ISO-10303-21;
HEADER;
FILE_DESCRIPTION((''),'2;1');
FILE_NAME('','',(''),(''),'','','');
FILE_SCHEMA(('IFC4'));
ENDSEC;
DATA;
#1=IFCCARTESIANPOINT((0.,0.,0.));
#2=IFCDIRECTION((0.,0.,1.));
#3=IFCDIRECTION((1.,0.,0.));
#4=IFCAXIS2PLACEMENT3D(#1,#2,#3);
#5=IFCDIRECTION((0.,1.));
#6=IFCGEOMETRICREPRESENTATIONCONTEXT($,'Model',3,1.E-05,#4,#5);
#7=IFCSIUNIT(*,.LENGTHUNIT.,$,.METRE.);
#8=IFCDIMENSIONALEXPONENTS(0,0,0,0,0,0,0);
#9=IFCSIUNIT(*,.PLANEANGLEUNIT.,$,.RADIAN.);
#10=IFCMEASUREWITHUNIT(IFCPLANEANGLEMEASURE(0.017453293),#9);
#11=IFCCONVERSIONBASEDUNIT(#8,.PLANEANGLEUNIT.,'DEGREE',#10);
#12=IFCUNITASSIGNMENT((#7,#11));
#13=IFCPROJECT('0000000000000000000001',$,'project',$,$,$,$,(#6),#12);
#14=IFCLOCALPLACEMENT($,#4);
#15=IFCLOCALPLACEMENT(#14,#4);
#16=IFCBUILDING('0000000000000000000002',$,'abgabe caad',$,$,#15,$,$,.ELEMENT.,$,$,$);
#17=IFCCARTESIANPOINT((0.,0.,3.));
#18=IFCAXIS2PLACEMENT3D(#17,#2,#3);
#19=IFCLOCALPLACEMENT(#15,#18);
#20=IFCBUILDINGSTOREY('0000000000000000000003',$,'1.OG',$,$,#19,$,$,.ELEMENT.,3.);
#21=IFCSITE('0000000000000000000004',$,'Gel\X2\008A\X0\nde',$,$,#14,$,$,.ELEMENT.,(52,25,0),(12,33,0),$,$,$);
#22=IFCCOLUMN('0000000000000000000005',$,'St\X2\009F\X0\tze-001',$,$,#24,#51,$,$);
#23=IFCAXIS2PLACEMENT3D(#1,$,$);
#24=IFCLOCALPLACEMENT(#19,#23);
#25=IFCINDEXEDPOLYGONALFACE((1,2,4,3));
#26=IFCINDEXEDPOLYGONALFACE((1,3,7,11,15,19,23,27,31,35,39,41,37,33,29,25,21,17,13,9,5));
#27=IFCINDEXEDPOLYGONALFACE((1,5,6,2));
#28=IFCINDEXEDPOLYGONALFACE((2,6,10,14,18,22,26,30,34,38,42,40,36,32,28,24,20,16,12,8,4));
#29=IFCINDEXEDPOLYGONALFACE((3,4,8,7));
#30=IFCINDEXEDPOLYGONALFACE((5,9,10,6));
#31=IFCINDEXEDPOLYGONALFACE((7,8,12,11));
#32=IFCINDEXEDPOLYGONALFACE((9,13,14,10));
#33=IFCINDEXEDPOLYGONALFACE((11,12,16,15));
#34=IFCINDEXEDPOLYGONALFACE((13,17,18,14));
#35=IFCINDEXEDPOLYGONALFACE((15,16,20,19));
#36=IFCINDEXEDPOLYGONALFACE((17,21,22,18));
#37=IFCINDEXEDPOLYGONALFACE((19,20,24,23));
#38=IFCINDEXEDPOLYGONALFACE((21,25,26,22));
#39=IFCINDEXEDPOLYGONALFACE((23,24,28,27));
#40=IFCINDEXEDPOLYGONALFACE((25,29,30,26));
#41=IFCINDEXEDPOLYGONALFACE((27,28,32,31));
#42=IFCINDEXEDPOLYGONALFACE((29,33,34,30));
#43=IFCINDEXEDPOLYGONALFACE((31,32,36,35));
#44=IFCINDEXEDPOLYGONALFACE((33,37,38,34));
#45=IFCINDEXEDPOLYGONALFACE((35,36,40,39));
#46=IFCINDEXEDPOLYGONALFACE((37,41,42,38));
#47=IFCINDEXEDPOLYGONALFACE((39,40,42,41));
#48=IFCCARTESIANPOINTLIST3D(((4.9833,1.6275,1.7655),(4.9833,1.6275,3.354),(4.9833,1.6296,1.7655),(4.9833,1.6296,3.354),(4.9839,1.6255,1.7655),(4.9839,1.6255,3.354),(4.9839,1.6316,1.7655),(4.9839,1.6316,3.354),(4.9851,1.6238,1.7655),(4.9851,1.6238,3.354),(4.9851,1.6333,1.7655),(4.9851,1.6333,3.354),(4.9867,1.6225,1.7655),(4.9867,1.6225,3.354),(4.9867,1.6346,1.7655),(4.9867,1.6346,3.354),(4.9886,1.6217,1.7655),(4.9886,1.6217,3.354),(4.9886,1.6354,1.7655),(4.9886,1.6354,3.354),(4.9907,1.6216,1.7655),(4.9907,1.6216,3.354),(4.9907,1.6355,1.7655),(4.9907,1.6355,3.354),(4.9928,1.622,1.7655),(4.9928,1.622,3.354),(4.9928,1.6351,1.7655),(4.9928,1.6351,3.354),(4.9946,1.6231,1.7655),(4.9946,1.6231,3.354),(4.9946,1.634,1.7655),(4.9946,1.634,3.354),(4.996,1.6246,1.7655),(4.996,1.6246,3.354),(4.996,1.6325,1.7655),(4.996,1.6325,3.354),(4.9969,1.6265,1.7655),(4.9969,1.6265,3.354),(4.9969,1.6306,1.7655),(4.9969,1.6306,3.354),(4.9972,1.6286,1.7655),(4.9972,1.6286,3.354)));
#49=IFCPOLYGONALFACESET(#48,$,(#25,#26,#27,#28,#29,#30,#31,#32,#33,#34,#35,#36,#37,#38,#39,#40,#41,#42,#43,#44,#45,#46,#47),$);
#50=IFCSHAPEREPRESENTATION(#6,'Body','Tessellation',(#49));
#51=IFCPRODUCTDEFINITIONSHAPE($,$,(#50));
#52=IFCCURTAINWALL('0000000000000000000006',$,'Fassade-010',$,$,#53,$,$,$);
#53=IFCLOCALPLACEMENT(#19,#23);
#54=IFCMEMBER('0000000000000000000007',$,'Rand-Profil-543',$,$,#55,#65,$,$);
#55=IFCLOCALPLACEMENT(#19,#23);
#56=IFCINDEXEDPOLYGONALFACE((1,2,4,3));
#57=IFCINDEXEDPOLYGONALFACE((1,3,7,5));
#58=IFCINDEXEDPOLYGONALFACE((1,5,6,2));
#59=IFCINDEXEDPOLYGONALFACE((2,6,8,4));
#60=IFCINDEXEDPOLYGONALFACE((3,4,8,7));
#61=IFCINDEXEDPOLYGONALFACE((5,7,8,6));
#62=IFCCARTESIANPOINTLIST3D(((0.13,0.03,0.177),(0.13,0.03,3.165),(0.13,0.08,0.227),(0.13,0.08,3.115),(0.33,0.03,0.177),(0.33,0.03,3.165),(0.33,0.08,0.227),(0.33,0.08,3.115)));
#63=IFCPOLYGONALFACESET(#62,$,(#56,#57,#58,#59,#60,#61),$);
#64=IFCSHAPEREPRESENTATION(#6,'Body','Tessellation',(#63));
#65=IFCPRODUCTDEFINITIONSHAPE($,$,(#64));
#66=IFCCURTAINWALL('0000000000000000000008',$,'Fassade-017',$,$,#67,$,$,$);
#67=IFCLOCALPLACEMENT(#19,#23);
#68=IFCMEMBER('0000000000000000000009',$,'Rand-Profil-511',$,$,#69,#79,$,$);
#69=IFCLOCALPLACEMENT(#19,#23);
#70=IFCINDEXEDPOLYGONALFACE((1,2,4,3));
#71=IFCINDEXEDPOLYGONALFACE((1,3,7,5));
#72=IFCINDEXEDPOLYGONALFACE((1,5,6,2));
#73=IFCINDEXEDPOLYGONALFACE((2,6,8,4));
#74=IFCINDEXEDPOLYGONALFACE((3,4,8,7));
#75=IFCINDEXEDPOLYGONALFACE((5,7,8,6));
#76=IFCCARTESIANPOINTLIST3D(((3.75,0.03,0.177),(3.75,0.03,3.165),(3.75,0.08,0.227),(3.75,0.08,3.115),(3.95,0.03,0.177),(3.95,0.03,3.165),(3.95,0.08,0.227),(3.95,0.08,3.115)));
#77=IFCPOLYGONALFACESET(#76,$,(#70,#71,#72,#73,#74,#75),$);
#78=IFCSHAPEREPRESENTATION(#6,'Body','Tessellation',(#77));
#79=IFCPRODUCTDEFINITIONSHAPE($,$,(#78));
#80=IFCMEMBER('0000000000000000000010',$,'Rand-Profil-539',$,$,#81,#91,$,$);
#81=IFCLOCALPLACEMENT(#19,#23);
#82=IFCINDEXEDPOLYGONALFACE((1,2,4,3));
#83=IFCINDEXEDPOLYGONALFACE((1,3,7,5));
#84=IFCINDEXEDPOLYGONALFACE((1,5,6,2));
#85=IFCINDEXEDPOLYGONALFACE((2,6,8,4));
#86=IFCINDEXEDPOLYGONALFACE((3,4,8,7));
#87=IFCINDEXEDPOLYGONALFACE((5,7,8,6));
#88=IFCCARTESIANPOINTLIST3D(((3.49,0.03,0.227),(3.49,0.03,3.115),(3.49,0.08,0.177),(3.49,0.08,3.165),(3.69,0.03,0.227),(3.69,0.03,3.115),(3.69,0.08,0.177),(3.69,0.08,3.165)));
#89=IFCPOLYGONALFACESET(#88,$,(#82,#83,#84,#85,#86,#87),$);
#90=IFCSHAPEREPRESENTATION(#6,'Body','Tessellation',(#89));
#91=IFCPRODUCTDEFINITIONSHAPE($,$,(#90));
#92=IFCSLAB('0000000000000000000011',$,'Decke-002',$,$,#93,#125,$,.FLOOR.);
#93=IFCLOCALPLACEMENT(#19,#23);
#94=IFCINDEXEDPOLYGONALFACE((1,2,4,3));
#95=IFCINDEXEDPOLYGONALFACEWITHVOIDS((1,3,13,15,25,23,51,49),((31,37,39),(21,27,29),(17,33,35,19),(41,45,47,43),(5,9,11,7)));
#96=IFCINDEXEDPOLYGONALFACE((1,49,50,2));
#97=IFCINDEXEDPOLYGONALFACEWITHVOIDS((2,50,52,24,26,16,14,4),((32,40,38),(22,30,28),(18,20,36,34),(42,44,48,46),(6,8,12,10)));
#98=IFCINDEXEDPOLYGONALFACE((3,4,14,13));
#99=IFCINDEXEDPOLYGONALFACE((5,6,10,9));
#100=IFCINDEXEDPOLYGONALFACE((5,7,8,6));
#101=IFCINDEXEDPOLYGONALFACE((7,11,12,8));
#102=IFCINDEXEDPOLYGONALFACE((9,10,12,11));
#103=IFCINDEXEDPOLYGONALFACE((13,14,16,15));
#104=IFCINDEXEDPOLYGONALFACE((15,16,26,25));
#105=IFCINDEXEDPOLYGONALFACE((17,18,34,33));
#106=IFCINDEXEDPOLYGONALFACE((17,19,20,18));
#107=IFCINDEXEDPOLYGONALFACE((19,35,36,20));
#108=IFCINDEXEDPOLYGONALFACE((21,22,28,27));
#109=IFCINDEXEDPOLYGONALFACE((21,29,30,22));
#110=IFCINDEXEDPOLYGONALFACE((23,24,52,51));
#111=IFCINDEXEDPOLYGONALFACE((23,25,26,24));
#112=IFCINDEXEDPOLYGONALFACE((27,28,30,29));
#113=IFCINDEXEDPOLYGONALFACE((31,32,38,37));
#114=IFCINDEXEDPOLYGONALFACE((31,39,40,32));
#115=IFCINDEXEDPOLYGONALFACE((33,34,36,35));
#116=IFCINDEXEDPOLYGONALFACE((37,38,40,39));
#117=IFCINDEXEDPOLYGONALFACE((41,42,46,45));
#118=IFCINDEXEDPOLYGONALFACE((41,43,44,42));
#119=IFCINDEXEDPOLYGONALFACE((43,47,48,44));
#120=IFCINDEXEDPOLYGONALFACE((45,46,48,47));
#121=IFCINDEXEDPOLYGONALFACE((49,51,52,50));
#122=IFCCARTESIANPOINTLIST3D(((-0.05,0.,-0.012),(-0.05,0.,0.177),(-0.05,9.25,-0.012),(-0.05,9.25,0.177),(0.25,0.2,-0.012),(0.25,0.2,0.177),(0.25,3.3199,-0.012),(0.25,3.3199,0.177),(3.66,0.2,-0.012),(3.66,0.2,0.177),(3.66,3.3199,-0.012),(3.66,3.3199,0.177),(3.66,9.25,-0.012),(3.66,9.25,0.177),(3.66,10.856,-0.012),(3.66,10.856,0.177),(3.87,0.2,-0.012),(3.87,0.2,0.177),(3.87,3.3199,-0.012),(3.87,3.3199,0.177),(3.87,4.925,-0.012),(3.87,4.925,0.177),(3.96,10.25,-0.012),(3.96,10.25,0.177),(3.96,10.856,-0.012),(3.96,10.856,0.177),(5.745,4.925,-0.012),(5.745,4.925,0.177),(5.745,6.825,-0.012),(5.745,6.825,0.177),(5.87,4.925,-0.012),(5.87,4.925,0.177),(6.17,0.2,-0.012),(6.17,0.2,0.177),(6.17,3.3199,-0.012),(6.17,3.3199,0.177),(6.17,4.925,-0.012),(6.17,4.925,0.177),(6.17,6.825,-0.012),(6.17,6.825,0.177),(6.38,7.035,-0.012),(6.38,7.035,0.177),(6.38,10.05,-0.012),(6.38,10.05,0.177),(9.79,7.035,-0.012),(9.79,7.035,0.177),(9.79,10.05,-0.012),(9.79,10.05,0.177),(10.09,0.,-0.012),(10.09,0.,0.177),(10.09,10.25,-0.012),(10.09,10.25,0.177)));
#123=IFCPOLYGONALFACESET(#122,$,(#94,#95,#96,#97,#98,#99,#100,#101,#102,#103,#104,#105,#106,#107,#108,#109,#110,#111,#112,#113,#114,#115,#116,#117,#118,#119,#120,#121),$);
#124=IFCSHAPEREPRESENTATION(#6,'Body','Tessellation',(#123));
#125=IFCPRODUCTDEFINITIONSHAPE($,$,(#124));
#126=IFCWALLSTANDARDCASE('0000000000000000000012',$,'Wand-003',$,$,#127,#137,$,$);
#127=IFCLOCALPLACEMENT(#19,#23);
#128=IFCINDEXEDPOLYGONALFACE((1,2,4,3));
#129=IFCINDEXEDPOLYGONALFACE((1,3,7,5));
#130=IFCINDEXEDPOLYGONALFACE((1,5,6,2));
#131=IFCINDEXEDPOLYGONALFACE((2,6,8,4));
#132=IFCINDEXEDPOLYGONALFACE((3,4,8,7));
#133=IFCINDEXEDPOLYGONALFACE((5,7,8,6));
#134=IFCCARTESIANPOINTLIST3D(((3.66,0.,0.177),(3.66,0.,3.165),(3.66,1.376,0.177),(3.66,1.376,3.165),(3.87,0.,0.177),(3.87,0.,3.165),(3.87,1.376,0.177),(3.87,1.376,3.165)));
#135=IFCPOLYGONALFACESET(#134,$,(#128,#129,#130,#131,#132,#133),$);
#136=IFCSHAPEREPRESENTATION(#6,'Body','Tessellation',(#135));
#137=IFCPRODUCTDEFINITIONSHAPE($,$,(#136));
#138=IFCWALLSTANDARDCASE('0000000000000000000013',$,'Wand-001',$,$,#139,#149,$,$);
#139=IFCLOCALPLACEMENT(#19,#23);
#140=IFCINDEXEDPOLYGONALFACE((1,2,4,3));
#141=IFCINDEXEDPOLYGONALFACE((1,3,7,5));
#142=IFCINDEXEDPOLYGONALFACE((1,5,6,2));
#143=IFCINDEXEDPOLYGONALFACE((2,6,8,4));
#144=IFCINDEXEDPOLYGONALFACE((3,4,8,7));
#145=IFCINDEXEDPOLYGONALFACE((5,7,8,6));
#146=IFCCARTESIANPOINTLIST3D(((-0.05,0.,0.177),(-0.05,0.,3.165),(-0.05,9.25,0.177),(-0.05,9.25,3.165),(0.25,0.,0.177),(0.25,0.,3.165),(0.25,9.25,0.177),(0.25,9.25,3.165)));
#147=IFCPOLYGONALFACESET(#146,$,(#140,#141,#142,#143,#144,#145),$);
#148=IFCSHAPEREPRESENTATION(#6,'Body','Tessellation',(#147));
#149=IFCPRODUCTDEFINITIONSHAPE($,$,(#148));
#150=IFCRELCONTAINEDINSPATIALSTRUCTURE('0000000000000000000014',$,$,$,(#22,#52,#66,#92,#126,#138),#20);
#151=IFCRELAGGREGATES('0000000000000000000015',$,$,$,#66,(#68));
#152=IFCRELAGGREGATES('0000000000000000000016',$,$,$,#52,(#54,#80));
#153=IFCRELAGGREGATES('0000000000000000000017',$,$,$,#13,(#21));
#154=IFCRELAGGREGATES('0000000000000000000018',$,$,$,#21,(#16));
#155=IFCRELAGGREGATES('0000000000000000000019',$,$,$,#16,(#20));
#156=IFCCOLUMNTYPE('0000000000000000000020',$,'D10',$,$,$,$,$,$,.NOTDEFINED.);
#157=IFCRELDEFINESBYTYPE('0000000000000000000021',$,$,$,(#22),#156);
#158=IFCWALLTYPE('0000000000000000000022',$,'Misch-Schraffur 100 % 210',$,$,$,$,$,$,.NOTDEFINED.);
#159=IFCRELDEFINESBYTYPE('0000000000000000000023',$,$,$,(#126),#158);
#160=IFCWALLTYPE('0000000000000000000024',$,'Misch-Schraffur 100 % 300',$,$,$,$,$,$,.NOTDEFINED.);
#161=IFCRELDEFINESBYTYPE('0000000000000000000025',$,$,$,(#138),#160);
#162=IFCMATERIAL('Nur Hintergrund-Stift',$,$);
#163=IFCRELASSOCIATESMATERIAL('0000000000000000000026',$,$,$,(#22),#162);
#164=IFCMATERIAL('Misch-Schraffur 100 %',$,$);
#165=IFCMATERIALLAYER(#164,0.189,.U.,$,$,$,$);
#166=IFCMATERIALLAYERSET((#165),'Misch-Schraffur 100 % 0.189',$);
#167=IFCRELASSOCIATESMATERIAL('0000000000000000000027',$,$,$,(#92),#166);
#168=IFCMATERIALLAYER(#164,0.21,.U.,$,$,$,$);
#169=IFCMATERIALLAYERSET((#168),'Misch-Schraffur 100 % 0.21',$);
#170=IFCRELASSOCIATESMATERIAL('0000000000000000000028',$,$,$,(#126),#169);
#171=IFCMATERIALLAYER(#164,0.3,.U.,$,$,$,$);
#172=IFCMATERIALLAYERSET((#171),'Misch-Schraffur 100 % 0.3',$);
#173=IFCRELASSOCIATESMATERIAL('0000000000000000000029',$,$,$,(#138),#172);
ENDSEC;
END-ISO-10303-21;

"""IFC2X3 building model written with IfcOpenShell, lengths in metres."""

from ifc_helpers import new_model, entity, si_unit, converted_unit, direction, frame, origin_with_axes, origin_2d_with_axis, place, context, project, spatial, polyline, circle, outline, extrude, clip, halfspace, material, layer, layer_set, layer_usage, type_object, element, aggregate, save


model = new_model("IFC2X3")

# Units and contexts
model_context = context("Model", 3, precision=1e-05, world=origin_with_axes(), true_north=direction((0.0, 1.0)))
ifc_project = project(units=[si_unit("LENGTHUNIT", "METRE"), converted_unit("PLANEANGLEUNIT", "DEGREE", entity("IfcPlaneAngleMeasure", 0.017453293), si_unit("PLANEANGLEUNIT", "RADIAN"), dimensions=[0, 0, 0, 0, 0, 0, 0])], contexts=[model_context])

# Site, building, storey
site_placement = place(None, origin_with_axes())
site = spatial("IfcSite", under=ifc_project, at=site_placement, Name="Gel\u008ande", CompositionType="ELEMENT", RefLatitude=(52, 25, 0), RefLongitude=(12, 33, 0))
building_placement = place(site_placement, origin_with_axes())
building = spatial("IfcBuilding", under=site, at=building_placement, Name="abgabe caad", CompositionType="ELEMENT")
storey_placement = place(building_placement, frame((0.0, 0.0, 3.0), z_axis=(0.0, 0.0, 1.0), x_axis=(1.0, 0.0, 0.0)))
storey = spatial("IfcBuildingStorey", under=building, at=storey_placement, Name="1.OG", CompositionType="ELEMENT", Elevation=3.0)

# Column
ifc_material_1 = material(Name="Nur Hintergrund-Stift")
column_type = type_object("IfcColumnType", Name="D10", PredefinedType="NOTDEFINED")
column_1_placement = place(storey_placement, frame((4.9902, 1.6286, 1.7655), z_axis=(0.0, 0.0, 1.0), x_axis=(1.0, 0.0, 0.0)))
element("IfcColumn", 1, at=column_1_placement, inside=storey, type_object=column_type, material=ifc_material_1, Name="St\u009ftze-001", context=model_context, shape_type="SweptSolid", body=[
    extrude(circle(Radius=0.007, at=origin_2d_with_axis()), origin_with_axes(), (0.0, 0.0, 1.0), 1.5885),
])

# Curtain walls, members
curtain_wall_1_placement = place(storey_placement, frame((3.075, 0.055, 0.202), z_axis=(0.0, 0.0, 1.0), x_axis=(1.0, 0.0, 0.0)))
curtain_wall_1 = element("IfcCurtainWall", 2, at=curtain_wall_1_placement, inside=storey, Name="Fassade-010")
member_1_placement = place(curtain_wall_1_placement, frame((-2.8, 0.0, 0.0), z_axis=(0.0, 0.0, 1.0), x_axis=(0.0, -1.0, 0.0)))
member_1 = element("IfcMember", 3, at=member_1_placement, Name="Rand-Profil-543", context=model_context, shape_type="Clipping", body=[
    clip(clip(extrude(outline(polyline([(-0.145, -0.025), (0.055, -0.025), (0.055, 0.025), (-0.145, 0.025), (-0.145, -0.025)])), frame((0.0, 0.0, -0.025), z_axis=(0.0, 0.0, 1.0), x_axis=(0.0, 1.0, 0.0)), (0.0, 0.0, 1.0), 2.988), halfspace(frame((0.0, 0.0, 0.0), z_axis=(0.707107, 0.0, 0.707107), x_axis=(-0.707107, 0.0, 0.707107)), True)), halfspace(frame((-1.469, 0.0, 1.469), z_axis=(0.707107, 0.0, -0.707107), x_axis=(0.707107, 0.0, 0.707107)), True)),
])
curtain_wall_2_placement = place(storey_placement, frame((5.595, 0.055, 0.202), z_axis=(0.0, 0.0, 1.0), x_axis=(1.0, 0.0, 0.0)))
curtain_wall_2 = element("IfcCurtainWall", 4, at=curtain_wall_2_placement, inside=storey, Name="Fassade-017")
member_2_placement = place(curtain_wall_2_placement, frame((-1.7, 0.0, 0.0), z_axis=(0.0, 0.0, 1.0), x_axis=(0.0, -1.0, 0.0)))
member_2 = element("IfcMember", 5, at=member_2_placement, Name="Rand-Profil-511", context=model_context, shape_type="Clipping", body=[
    clip(clip(extrude(outline(polyline([(-0.145, -0.025), (0.055, -0.025), (0.055, 0.025), (-0.145, 0.025), (-0.145, -0.025)])), frame((0.0, 0.0, -0.025), z_axis=(0.0, 0.0, 1.0), x_axis=(0.0, 1.0, 0.0)), (0.0, 0.0, 1.0), 2.988), halfspace(frame((0.0, 0.0, 0.0), z_axis=(0.707107, 0.0, 0.707107), x_axis=(-0.707107, 0.0, 0.707107)), True)), halfspace(frame((-1.469, 0.0, 1.469), z_axis=(0.707107, 0.0, -0.707107), x_axis=(0.707107, 0.0, 0.707107)), True)),
])

# Member
member_3_placement = place(curtain_wall_1_placement, frame((0.56, 0.0, 0.0), z_axis=(0.0, 0.0, 1.0), x_axis=(0.0, -1.0, 0.0)))
member_3 = element("IfcMember", 6, at=member_3_placement, Name="Rand-Profil-539", context=model_context, shape_type="Clipping", body=[
    clip(clip(extrude(outline(polyline([(-0.145, -0.025), (0.055, -0.025), (0.055, 0.025), (-0.145, 0.025), (-0.145, -0.025)])), frame((0.0, 0.0, -0.025), z_axis=(0.0, 0.0, 1.0), x_axis=(0.0, 1.0, 0.0)), (0.0, 0.0, 1.0), 2.988), halfspace(frame((0.0, 0.0, 0.0), z_axis=(-0.707107, 0.0, 0.707107), x_axis=(-0.707107, 0.0, -0.707107)), True)), halfspace(frame((1.469, 0.0, 1.469), z_axis=(-0.707107, 0.0, -0.707107), x_axis=(0.707107, 0.0, -0.707107)), True)),
])

aggregate(curtain_wall_2, [member_2])

# Slab
ifc_material_2 = material(Name="Misch-Schraffur 100 %")
ifc_layer_1 = layer(ifc_material_2, 0.189, ventilated="UNKNOWN")
ifc_layer_set_1 = layer_set([ifc_layer_1], Name="Misch-Schraffur 100 % 0.189")
ifc_layer_usage_1 = layer_usage(ifc_layer_set_1, "AXIS3", "NEGATIVE", 0.189)
slab_placement = place(storey_placement, frame((-0.05, 0.0, -0.012), z_axis=(0.0, 0.0, 1.0), x_axis=(1.0, 0.0, 0.0)))
element("IfcSlab", 7, at=slab_placement, inside=storey, material=ifc_layer_usage_1, Name="Decke-002", PredefinedType="FLOOR", context=model_context, shape_type="SweptSolid", body=[
    extrude(outline(polyline([(0.0, 0.0), (10.14, 0.0), (10.14, 10.25), (4.01, 10.25), (4.01, 10.856), (3.71, 10.856), (3.71, 9.25), (0.0, 9.25), (0.0, 0.0)]), holes=[polyline([(3.71, 0.2), (0.3, 0.2), (0.3, 3.3199), (3.71, 3.3199), (3.71, 0.2)]), polyline([(3.92, 0.2), (3.92, 3.3199), (6.22, 3.3199), (6.22, 0.2), (3.92, 0.2)]), polyline([(5.795, 6.825), (5.795, 4.925), (3.92, 4.925), (5.795, 6.825)]), polyline([(6.22, 6.825), (6.22, 4.925), (5.92, 4.925), (6.22, 6.825)]), polyline([(9.84, 10.05), (9.84, 7.035), (6.43, 7.035), (6.43, 10.05), (9.84, 10.05)])]), origin_with_axes(), (0.0, 0.0, 1.0), 0.189),
])

aggregate(curtain_wall_1, [member_1, member_3])

# Walls
ifc_layer_2 = layer(ifc_material_2, 0.21, ventilated="UNKNOWN")
ifc_layer_set_2 = layer_set([ifc_layer_2], Name="Misch-Schraffur 100 % 0.21")
ifc_layer_usage_2 = layer_usage(ifc_layer_set_2, "AXIS2", "NEGATIVE", 0.0)
wall_type_1 = type_object("IfcWallType", Name="Misch-Schraffur 100 % 210", PredefinedType="NOTDEFINED")
wall_1_placement = place(storey_placement, frame((3.66, 0.0, 0.177), z_axis=(0.0, 0.0, 1.0), x_axis=(0.0, 1.0, 0.0)))
element("IfcWallStandardCase", 8, at=wall_1_placement, inside=storey, type_object=wall_type_1, material=ifc_layer_usage_2, Name="Wand-003", context=model_context, shape_type="SweptSolid", body=[
    extrude(outline(polyline([(0.0, -0.21), (1.376, -0.21), (1.376, 0.0), (0.0, 0.0), (0.0, -0.21)])), origin_with_axes(), (0.0, 0.0, 1.0), 2.988),
])
ifc_layer_3 = layer(ifc_material_2, 0.3, ventilated="UNKNOWN")
ifc_layer_set_3 = layer_set([ifc_layer_3], Name="Misch-Schraffur 100 % 0.3")
ifc_layer_usage_3 = layer_usage(ifc_layer_set_3, "AXIS2", "NEGATIVE", 0.0)
wall_type_2 = type_object("IfcWallType", Name="Misch-Schraffur 100 % 300", PredefinedType="NOTDEFINED")
wall_2_placement = place(storey_placement, frame((-0.05, 0.0, 0.177), z_axis=(0.0, 0.0, 1.0), x_axis=(0.0, 1.0, 0.0)))
element("IfcWallStandardCase", 9, at=wall_2_placement, inside=storey, type_object=wall_type_2, material=ifc_layer_usage_3, Name="Wand-001", context=model_context, shape_type="SweptSolid", body=[
    extrude(outline(polyline([(0.0, -0.3), (9.25, -0.3), (9.25, 0.0), (0.0, 0.0), (0.0, -0.3)])), origin_with_axes(), (0.0, 0.0, 1.0), 2.988),
])

save(model, "model.ifc")
